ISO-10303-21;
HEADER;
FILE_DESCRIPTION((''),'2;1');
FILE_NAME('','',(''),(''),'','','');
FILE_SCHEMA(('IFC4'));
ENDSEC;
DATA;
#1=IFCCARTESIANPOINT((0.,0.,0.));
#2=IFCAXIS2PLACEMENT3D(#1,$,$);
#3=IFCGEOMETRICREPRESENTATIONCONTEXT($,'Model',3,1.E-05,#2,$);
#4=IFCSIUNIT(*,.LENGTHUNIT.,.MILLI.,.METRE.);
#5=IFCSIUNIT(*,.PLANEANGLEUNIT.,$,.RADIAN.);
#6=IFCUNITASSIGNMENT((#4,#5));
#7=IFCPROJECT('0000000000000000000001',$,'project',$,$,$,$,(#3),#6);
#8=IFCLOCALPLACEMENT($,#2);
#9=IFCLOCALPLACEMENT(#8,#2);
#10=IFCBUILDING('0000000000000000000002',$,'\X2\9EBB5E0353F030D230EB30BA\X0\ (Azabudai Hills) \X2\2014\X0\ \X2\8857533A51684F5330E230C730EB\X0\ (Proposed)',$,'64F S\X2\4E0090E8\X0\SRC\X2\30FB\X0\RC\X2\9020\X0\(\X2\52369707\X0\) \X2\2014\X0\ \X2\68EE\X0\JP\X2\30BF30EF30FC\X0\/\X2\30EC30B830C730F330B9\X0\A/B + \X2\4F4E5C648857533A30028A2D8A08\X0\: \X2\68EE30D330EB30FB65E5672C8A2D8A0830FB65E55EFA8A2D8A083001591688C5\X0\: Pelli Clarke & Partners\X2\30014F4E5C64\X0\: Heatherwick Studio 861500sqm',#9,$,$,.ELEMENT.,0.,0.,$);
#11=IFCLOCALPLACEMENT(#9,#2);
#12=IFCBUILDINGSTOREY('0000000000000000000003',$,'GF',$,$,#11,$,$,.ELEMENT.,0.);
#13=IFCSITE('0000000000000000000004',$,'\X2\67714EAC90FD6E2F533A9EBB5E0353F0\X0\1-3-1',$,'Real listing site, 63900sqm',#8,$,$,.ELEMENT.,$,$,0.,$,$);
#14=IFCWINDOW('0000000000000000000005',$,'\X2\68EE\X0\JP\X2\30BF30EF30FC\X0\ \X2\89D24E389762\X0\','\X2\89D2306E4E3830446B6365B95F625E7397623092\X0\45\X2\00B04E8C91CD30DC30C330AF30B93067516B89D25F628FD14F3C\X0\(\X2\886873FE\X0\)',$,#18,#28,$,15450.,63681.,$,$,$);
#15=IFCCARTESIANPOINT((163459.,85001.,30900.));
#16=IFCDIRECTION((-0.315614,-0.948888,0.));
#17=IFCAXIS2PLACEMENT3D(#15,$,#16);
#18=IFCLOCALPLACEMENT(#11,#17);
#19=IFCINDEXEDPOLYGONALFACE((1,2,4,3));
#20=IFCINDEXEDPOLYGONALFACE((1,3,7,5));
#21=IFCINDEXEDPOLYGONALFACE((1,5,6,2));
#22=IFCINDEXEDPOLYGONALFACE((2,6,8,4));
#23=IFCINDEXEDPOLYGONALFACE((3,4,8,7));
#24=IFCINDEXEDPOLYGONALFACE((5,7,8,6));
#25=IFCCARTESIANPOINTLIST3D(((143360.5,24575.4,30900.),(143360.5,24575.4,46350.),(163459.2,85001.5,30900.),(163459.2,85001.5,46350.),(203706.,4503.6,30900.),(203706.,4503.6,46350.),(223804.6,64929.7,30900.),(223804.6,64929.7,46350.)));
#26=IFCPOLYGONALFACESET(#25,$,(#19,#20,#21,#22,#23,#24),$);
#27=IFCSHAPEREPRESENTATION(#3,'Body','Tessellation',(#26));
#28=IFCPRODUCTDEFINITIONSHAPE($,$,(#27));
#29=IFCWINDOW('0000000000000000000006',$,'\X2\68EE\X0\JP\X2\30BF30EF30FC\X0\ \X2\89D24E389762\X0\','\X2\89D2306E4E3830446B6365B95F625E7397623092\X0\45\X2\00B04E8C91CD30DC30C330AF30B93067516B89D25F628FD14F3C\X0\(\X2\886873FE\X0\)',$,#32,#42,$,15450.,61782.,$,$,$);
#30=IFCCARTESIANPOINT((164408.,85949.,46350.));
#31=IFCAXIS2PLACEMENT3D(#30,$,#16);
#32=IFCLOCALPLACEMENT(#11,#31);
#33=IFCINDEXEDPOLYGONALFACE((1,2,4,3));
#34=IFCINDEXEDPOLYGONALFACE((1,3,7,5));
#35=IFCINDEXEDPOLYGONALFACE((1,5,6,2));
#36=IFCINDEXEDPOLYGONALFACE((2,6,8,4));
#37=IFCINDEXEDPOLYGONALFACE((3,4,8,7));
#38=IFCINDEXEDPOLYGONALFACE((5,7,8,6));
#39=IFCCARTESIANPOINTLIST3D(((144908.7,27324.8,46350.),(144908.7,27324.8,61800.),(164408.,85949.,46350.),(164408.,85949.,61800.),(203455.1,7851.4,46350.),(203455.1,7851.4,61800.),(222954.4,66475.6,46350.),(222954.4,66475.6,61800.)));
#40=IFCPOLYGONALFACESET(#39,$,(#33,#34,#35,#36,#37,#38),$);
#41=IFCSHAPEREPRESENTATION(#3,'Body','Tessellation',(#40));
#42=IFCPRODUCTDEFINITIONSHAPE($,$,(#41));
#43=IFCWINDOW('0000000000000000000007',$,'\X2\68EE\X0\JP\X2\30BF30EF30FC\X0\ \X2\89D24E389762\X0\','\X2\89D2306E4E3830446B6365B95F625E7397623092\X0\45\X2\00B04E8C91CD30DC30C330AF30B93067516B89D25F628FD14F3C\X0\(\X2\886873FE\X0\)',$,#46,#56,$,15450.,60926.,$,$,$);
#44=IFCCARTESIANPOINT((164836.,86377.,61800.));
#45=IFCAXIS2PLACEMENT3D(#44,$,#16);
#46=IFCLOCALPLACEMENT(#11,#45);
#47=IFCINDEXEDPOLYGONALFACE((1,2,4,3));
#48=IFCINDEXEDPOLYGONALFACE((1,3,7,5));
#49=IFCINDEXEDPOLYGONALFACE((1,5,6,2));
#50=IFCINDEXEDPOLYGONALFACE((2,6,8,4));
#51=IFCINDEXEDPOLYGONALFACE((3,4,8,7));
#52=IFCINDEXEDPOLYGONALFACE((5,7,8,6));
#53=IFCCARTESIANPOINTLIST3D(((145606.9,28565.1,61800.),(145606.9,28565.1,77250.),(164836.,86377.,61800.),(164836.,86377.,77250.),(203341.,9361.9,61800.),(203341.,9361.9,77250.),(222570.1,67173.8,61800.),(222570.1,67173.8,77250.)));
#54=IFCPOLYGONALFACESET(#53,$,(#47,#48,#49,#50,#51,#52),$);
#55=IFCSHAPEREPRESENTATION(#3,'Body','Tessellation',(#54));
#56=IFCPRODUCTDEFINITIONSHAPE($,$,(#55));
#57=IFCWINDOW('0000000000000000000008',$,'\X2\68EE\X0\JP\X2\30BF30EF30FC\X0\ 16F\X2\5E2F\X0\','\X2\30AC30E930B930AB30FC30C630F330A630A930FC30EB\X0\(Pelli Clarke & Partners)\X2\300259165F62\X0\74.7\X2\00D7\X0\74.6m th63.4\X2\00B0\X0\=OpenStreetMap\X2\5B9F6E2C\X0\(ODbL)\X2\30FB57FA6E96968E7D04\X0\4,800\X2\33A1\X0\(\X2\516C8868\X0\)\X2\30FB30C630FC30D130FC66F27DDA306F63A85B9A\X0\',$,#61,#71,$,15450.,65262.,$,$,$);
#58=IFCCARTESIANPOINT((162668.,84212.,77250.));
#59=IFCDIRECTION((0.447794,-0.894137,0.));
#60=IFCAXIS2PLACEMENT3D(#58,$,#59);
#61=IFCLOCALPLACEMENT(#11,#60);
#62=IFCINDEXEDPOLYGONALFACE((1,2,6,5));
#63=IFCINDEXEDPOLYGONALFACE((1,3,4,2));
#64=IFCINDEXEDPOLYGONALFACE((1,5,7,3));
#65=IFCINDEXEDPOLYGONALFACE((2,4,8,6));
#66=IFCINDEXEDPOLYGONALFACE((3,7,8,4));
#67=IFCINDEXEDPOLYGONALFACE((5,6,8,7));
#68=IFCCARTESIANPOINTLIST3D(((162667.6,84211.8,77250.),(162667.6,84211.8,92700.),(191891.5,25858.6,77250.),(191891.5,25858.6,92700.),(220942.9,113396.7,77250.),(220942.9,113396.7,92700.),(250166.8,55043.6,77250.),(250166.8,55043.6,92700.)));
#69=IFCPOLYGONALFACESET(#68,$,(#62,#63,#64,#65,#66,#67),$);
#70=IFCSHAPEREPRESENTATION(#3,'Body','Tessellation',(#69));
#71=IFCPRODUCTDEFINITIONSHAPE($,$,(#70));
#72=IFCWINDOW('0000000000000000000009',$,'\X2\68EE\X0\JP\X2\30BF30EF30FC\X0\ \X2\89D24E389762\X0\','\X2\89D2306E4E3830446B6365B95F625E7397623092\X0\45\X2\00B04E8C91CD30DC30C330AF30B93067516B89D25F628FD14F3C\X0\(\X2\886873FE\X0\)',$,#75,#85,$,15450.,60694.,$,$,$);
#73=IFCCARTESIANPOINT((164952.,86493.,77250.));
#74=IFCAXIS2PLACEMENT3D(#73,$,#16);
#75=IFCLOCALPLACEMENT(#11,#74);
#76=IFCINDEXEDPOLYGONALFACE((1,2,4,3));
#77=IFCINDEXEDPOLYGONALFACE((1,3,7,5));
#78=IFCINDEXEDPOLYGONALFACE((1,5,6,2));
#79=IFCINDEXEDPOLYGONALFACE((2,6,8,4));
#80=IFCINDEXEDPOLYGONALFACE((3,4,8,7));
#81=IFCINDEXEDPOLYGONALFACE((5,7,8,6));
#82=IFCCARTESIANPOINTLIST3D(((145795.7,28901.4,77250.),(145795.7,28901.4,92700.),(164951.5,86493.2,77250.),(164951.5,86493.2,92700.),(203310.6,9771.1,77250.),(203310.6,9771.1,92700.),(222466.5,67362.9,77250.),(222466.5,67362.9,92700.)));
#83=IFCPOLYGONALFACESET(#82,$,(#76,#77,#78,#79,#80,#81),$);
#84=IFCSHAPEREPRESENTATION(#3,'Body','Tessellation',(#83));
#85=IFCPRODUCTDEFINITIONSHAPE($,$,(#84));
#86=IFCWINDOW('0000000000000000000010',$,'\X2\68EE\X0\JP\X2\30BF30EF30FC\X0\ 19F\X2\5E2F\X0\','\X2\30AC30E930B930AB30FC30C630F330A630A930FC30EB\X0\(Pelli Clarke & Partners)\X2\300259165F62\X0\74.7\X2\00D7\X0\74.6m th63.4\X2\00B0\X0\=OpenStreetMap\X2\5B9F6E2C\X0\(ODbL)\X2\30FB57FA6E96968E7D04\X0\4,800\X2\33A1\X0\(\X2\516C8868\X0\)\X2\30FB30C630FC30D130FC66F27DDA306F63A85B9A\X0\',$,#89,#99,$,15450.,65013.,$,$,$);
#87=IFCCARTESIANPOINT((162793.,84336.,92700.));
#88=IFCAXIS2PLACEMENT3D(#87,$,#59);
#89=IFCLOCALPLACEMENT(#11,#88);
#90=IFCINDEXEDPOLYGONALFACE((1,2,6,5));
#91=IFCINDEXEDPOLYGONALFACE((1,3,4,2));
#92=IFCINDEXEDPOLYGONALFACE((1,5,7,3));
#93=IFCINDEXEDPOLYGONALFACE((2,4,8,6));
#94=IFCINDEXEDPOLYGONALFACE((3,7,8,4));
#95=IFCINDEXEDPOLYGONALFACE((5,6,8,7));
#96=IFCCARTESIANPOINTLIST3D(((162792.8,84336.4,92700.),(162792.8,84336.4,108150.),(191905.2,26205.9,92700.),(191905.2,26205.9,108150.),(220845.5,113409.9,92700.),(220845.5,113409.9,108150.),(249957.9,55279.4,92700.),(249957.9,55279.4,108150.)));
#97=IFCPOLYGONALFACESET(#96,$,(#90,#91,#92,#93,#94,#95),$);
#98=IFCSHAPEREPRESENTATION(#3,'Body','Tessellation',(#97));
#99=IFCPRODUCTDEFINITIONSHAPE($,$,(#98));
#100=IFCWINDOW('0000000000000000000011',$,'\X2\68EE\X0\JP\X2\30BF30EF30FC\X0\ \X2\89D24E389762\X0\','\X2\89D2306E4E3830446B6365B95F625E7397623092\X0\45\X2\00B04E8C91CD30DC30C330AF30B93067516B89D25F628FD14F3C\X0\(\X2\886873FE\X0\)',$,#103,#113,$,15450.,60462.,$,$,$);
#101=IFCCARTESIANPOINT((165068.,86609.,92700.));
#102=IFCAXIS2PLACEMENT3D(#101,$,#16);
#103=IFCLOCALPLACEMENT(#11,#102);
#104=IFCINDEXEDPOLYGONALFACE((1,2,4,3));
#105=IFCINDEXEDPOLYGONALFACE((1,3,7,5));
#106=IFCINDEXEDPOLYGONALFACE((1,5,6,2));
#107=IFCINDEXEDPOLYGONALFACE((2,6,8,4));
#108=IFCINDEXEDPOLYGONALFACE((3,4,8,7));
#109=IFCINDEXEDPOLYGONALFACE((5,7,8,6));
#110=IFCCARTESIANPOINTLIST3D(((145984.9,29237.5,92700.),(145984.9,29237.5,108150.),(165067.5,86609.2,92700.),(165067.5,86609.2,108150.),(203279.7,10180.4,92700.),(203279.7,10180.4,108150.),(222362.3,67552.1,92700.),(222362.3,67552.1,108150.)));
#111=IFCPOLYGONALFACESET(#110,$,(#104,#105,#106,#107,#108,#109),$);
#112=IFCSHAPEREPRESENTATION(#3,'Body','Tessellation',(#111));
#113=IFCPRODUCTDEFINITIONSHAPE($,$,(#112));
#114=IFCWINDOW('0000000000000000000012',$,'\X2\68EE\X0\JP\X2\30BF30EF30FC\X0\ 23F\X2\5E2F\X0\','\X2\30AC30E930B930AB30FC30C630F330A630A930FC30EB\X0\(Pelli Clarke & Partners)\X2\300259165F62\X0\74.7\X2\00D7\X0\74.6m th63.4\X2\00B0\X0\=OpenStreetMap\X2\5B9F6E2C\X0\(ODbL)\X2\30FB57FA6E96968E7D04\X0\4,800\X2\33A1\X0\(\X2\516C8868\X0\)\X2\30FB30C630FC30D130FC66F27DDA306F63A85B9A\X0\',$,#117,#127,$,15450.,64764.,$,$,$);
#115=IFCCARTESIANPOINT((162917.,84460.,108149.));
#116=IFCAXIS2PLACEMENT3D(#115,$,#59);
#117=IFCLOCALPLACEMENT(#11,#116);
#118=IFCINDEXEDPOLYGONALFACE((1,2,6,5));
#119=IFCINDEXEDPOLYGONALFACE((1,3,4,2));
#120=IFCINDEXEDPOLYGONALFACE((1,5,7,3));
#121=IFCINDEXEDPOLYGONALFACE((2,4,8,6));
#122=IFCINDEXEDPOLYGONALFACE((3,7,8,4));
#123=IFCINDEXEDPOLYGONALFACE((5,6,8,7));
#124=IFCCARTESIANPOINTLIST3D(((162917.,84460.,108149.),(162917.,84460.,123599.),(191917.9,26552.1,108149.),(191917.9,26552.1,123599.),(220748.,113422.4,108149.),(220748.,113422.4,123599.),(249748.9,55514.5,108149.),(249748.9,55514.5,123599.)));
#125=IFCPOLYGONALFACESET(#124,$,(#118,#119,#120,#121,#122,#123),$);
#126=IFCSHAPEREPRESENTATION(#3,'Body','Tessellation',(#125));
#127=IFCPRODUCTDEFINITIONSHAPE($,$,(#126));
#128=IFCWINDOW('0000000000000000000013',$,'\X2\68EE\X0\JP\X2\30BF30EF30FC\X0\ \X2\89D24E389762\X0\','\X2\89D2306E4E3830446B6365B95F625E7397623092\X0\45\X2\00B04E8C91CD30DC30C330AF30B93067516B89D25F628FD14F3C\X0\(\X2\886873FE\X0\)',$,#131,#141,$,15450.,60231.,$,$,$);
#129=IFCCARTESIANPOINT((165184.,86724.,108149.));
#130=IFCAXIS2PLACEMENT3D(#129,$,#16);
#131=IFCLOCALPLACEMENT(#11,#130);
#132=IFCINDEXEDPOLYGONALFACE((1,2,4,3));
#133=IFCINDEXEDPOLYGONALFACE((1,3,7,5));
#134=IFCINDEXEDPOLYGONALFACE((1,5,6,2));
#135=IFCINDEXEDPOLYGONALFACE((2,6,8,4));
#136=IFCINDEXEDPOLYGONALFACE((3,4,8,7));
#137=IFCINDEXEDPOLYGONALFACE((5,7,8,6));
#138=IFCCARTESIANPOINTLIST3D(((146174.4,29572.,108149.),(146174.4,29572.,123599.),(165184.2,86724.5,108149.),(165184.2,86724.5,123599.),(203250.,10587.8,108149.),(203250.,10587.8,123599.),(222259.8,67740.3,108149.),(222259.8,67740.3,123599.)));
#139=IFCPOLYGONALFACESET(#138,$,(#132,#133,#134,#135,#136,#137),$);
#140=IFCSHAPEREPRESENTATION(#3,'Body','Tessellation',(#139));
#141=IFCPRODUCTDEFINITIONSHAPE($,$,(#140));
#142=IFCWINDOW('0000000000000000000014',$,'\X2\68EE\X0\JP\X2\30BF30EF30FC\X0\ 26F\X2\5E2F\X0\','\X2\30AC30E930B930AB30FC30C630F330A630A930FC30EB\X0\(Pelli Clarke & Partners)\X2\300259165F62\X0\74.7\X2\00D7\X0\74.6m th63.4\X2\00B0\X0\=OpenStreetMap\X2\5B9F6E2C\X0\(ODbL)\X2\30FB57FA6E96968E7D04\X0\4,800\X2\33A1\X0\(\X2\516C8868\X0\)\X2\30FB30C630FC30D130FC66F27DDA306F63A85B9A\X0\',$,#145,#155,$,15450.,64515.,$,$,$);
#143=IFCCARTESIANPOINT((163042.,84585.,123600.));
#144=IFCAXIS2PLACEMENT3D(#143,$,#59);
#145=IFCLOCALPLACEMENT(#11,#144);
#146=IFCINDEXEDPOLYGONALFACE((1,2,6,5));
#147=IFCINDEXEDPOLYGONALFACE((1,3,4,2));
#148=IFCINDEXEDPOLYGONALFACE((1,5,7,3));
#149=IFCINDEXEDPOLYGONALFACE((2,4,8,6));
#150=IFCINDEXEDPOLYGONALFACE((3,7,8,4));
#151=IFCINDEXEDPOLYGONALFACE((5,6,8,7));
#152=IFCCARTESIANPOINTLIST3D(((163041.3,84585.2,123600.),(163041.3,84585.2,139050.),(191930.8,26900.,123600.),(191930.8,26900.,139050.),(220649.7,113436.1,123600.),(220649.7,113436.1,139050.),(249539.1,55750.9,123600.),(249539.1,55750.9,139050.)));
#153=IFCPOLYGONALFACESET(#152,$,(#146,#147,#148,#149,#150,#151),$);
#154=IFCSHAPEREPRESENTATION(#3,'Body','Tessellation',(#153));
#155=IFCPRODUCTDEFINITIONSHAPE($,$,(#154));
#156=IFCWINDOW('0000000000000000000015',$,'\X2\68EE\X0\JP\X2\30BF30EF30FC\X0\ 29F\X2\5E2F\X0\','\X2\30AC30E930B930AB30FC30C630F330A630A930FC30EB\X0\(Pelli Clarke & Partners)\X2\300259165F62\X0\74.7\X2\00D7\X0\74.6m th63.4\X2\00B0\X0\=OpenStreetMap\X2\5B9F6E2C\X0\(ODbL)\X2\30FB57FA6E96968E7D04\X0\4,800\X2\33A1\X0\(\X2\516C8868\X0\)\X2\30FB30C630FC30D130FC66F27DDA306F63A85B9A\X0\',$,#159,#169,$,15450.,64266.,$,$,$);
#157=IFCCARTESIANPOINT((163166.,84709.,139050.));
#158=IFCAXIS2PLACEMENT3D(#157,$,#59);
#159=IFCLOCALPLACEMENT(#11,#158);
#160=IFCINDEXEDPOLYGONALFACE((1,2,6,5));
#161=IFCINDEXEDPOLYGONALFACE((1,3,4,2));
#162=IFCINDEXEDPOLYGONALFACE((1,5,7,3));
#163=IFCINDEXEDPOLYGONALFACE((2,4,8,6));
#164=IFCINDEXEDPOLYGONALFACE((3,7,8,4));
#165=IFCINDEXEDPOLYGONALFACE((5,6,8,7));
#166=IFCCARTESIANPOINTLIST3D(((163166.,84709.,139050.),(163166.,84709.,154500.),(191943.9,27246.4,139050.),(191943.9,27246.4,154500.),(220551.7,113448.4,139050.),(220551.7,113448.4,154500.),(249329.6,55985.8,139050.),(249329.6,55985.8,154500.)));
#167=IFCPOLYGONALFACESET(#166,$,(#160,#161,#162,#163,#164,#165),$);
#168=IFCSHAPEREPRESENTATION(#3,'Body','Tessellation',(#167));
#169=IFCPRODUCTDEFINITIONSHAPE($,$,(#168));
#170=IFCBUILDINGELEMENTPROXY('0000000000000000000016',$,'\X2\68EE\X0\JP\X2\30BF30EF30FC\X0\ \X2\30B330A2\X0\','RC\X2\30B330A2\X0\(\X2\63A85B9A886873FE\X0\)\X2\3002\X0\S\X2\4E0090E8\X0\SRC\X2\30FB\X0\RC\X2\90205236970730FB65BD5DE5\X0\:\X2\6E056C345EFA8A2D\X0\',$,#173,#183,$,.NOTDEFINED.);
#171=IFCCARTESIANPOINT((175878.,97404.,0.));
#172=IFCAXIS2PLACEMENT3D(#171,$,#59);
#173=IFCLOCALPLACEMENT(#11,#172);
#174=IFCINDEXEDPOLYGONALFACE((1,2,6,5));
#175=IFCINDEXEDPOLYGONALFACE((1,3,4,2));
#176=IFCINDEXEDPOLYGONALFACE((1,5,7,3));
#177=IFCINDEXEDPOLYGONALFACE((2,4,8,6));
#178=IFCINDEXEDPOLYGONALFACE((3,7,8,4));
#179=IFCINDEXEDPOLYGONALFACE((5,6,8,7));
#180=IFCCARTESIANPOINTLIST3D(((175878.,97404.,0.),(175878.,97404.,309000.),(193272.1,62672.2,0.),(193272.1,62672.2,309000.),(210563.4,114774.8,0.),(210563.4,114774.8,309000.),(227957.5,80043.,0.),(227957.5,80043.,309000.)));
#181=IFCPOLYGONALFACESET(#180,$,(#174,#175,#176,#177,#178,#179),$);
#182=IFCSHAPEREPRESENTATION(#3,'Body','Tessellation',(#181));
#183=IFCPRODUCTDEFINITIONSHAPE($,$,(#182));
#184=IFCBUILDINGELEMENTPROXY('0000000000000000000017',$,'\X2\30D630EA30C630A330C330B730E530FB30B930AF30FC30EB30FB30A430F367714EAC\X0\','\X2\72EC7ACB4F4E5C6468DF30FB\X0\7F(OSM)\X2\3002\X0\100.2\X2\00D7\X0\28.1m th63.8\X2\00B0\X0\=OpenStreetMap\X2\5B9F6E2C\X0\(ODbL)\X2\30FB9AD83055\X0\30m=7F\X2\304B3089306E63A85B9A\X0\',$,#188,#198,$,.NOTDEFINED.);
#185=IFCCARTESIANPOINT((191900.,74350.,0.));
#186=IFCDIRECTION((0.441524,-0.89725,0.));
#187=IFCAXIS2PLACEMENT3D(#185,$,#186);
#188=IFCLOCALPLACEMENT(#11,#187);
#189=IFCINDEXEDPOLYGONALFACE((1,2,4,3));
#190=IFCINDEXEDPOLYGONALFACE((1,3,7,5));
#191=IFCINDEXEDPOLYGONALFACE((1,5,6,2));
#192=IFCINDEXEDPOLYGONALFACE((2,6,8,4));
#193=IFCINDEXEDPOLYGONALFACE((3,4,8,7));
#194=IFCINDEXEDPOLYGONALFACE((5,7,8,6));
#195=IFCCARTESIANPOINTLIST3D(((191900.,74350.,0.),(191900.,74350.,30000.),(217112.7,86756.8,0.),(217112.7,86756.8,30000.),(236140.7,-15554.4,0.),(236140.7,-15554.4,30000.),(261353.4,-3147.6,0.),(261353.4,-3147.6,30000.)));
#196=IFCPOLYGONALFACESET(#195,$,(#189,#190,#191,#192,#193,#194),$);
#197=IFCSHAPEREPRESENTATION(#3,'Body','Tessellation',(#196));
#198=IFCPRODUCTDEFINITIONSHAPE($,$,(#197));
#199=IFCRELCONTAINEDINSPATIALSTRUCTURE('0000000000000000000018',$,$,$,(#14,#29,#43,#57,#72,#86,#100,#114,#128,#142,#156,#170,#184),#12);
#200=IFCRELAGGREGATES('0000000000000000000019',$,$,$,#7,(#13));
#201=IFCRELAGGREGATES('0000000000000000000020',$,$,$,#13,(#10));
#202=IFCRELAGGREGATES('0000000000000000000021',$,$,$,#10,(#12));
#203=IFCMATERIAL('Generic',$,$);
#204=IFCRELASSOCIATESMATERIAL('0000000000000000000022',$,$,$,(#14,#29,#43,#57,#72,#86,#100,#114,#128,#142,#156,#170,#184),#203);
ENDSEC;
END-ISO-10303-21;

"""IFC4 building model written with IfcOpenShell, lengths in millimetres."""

from ifc_helpers import new_model, si_unit, frame, frame_2d, origin, place, context, project, spatial, rectangle, extrude, material, element, save


model = new_model("IFC4")

# Units and contexts
model_context = context("Model", 3, precision=1e-05, world=origin())
ifc_project = project(units=[si_unit("LENGTHUNIT", "METRE", prefix="MILLI"), si_unit("PLANEANGLEUNIT", "RADIAN")], contexts=[model_context])

# Site, building, storey
site_placement = place(None, origin())
site = spatial("IfcSite", under=ifc_project, at=site_placement, Name="東京都港区麻布台1-3-1", ObjectType="Real listing site, 63900sqm", CompositionType="ELEMENT", RefElevation=0.0)
building_placement = place(site_placement, origin())
building = spatial("IfcBuilding", under=site, at=building_placement, Name="麻布台ヒルズ (Azabudai Hills) — 街区全体モデル (Proposed)", ObjectType="64F S一部SRC・RC造(制震) — 森JPタワー/レジデンスA/B + 低層街区。設計: 森ビル・日本設計・日建設計、外装: Pelli Clarke & Partners、低層: Heatherwick Studio 861500sqm", CompositionType="ELEMENT", ElevationOfRefHeight=0.0, ElevationOfTerrain=0.0)
storey_placement = place(building_placement, origin())
storey = spatial("IfcBuildingStorey", under=building, at=storey_placement, Name="GF", CompositionType="ELEMENT", Elevation=0.0)

# Windows
ifc_material = material(Name="Generic")
window_1_placement = place(storey_placement, frame((163459.0, 85001.0, 30900.0), x_axis=(-0.315614, -0.948888, 0.0)))
element("IfcWindow", 1, at=window_1_placement, inside=storey, material=ifc_material, Name="森JPタワー 角丸面", Description="角の丸い正方形平面を45°二重ボックスで八角形近似(表現)", OverallHeight=15450.0, OverallWidth=63681.0, context=model_context, shape_type="SweptSolid", body=[
    extrude(rectangle(XDim=63681.0, YDim=63596.0, at=frame_2d((31840.0, 31798.0))), frame((163459.0, 85001.0, 30900.0), x_axis=(-0.315614, -0.948888, 0.0)), (0.0, 0.0, 1.0), 15450.0),
])
window_2_placement = place(storey_placement, frame((164408.0, 85949.0, 46350.0), x_axis=(-0.315614, -0.948888, 0.0)))
element("IfcWindow", 2, at=window_2_placement, inside=storey, material=ifc_material, Name="森JPタワー 角丸面", Description="角の丸い正方形平面を45°二重ボックスで八角形近似(表現)", OverallHeight=15450.0, OverallWidth=61782.0, context=model_context, shape_type="SweptSolid", body=[
    extrude(rectangle(XDim=61782.0, YDim=61700.0, at=frame_2d((30891.0, 30850.0))), frame((164408.0, 85949.0, 46350.0), x_axis=(-0.315614, -0.948888, 0.0)), (0.0, 0.0, 1.0), 15450.0),
])
window_3_placement = place(storey_placement, frame((164836.0, 86377.0, 61800.0), x_axis=(-0.315614, -0.948888, 0.0)))
element("IfcWindow", 3, at=window_3_placement, inside=storey, material=ifc_material, Name="森JPタワー 角丸面", Description="角の丸い正方形平面を45°二重ボックスで八角形近似(表現)", OverallHeight=15450.0, OverallWidth=60926.0, context=model_context, shape_type="SweptSolid", body=[
    extrude(rectangle(XDim=60926.0, YDim=60844.0, at=frame_2d((30463.0, 30422.0))), frame((164836.0, 86377.0, 61800.0), x_axis=(-0.315614, -0.948888, 0.0)), (0.0, 0.0, 1.0), 15450.0),
])
window_4_placement = place(storey_placement, frame((162668.0, 84212.0, 77250.0), x_axis=(0.447794, -0.894137, 0.0)))
element("IfcWindow", 4, at=window_4_placement, inside=storey, material=ifc_material, Name="森JPタワー 16F帯", Description="ガラスカーテンウォール(Pelli Clarke & Partners)。外形74.7×74.6m th63.4°=OpenStreetMap実測(ODbL)・基準階約4,800㎡(公表)・テーパー曲線は推定", OverallHeight=15450.0, OverallWidth=65262.0, context=model_context, shape_type="SweptSolid", body=[
    extrude(rectangle(XDim=65262.0, YDim=65175.0, at=frame_2d((32631.0, 32587.0))), frame((162668.0, 84212.0, 77250.0), x_axis=(0.447794, -0.894137, 0.0)), (0.0, 0.0, 1.0), 15450.0),
])
window_5_placement = place(storey_placement, frame((164952.0, 86493.0, 77250.0), x_axis=(-0.315614, -0.948888, 0.0)))
element("IfcWindow", 5, at=window_5_placement, inside=storey, material=ifc_material, Name="森JPタワー 角丸面", Description="角の丸い正方形平面を45°二重ボックスで八角形近似(表現)", OverallHeight=15450.0, OverallWidth=60694.0, context=model_context, shape_type="SweptSolid", body=[
    extrude(rectangle(XDim=60694.0, YDim=60613.0, at=frame_2d((30347.0, 30306.0))), frame((164952.0, 86493.0, 77250.0), x_axis=(-0.315614, -0.948888, 0.0)), (0.0, 0.0, 1.0), 15450.0),
])
window_6_placement = place(storey_placement, frame((162793.0, 84336.0, 92700.0), x_axis=(0.447794, -0.894137, 0.0)))
element("IfcWindow", 6, at=window_6_placement, inside=storey, material=ifc_material, Name="森JPタワー 19F帯", Description="ガラスカーテンウォール(Pelli Clarke & Partners)。外形74.7×74.6m th63.4°=OpenStreetMap実測(ODbL)・基準階約4,800㎡(公表)・テーパー曲線は推定", OverallHeight=15450.0, OverallWidth=65013.0, context=model_context, shape_type="SweptSolid", body=[
    extrude(rectangle(XDim=65013.0, YDim=64926.0, at=frame_2d((32506.0, 32463.0))), frame((162793.0, 84336.0, 92700.0), x_axis=(0.447794, -0.894137, 0.0)), (0.0, 0.0, 1.0), 15450.0),
])
window_7_placement = place(storey_placement, frame((165068.0, 86609.0, 92700.0), x_axis=(-0.315614, -0.948888, 0.0)))
element("IfcWindow", 7, at=window_7_placement, inside=storey, material=ifc_material, Name="森JPタワー 角丸面", Description="角の丸い正方形平面を45°二重ボックスで八角形近似(表現)", OverallHeight=15450.0, OverallWidth=60462.0, context=model_context, shape_type="SweptSolid", body=[
    extrude(rectangle(XDim=60462.0, YDim=60381.0, at=frame_2d((30231.0, 30190.0))), frame((165068.0, 86609.0, 92700.0), x_axis=(-0.315614, -0.948888, 0.0)), (0.0, 0.0, 1.0), 15450.0),
])
window_8_placement = place(storey_placement, frame((162917.0, 84460.0, 108149.0), x_axis=(0.447794, -0.894137, 0.0)))
element("IfcWindow", 8, at=window_8_placement, inside=storey, material=ifc_material, Name="森JPタワー 23F帯", Description="ガラスカーテンウォール(Pelli Clarke & Partners)。外形74.7×74.6m th63.4°=OpenStreetMap実測(ODbL)・基準階約4,800㎡(公表)・テーパー曲線は推定", OverallHeight=15450.0, OverallWidth=64764.0, context=model_context, shape_type="SweptSolid", body=[
    extrude(rectangle(XDim=64764.0, YDim=64678.0, at=frame_2d((32382.0, 32339.0))), frame((162917.0, 84460.0, 108149.0), x_axis=(0.447794, -0.894137, 0.0)), (0.0, 0.0, 1.0), 15450.0),
])
window_9_placement = place(storey_placement, frame((165184.0, 86724.0, 108149.0), x_axis=(-0.315614, -0.948888, 0.0)))
element("IfcWindow", 9, at=window_9_placement, inside=storey, material=ifc_material, Name="森JPタワー 角丸面", Description="角の丸い正方形平面を45°二重ボックスで八角形近似(表現)", OverallHeight=15450.0, OverallWidth=60231.0, context=model_context, shape_type="SweptSolid", body=[
    extrude(rectangle(XDim=60231.0, YDim=60150.0, at=frame_2d((30115.0, 30075.0))), frame((165184.0, 86724.0, 108149.0), x_axis=(-0.315614, -0.948888, 0.0)), (0.0, 0.0, 1.0), 15450.0),
])
window_10_placement = place(storey_placement, frame((163042.0, 84585.0, 123600.0), x_axis=(0.447794, -0.894137, 0.0)))
element("IfcWindow", 10, at=window_10_placement, inside=storey, material=ifc_material, Name="森JPタワー 26F帯", Description="ガラスカーテンウォール(Pelli Clarke & Partners)。外形74.7×74.6m th63.4°=OpenStreetMap実測(ODbL)・基準階約4,800㎡(公表)・テーパー曲線は推定", OverallHeight=15450.0, OverallWidth=64515.0, context=model_context, shape_type="SweptSolid", body=[
    extrude(rectangle(XDim=64515.0, YDim=64429.0, at=frame_2d((32257.0, 32214.0))), frame((163042.0, 84585.0, 123600.0), x_axis=(0.447794, -0.894137, 0.0)), (0.0, 0.0, 1.0), 15450.0),
])
window_11_placement = place(storey_placement, frame((163166.0, 84709.0, 139050.0), x_axis=(0.447794, -0.894137, 0.0)))
element("IfcWindow", 11, at=window_11_placement, inside=storey, material=ifc_material, Name="森JPタワー 29F帯", Description="ガラスカーテンウォール(Pelli Clarke & Partners)。外形74.7×74.6m th63.4°=OpenStreetMap実測(ODbL)・基準階約4,800㎡(公表)・テーパー曲線は推定", OverallHeight=15450.0, OverallWidth=64266.0, context=model_context, shape_type="SweptSolid", body=[
    extrude(rectangle(XDim=64266.0, YDim=64180.0, at=frame_2d((32133.0, 32090.0))), frame((163166.0, 84709.0, 139050.0), x_axis=(0.447794, -0.894137, 0.0)), (0.0, 0.0, 1.0), 15450.0),
])

# Building element proxies
proxy_1_placement = place(storey_placement, frame((175878.0, 97404.0, 0.0), x_axis=(0.447794, -0.894137, 0.0)))
element("IfcBuildingElementProxy", 12, at=proxy_1_placement, inside=storey, material=ifc_material, Name="森JPタワー コア", Description="RCコア(推定表現)。S一部SRC・RC造制震・施工:清水建設", PredefinedType="NOTDEFINED", context=model_context, shape_type="SweptSolid", body=[
    extrude(rectangle(XDim=38844.0, YDim=38792.0, at=frame_2d((19422.0, 19396.0))), frame((175878.0, 97404.0, 0.0), x_axis=(0.447794, -0.894137, 0.0)), (0.0, 0.0, 1.0), 309000.0),
])
proxy_2_placement = place(storey_placement, frame((191900.0, 74350.0, 0.0), x_axis=(0.441524, -0.89725, 0.0)))
element("IfcBuildingElementProxy", 13, at=proxy_2_placement, inside=storey, material=ifc_material, Name="ブリティッシュ・スクール・イン東京", Description="独立低層棟・7F(OSM)。100.2×28.1m th63.8°=OpenStreetMap実測(ODbL)・高さ30m=7Fからの推定", PredefinedType="NOTDEFINED", context=model_context, shape_type="SweptSolid", body=[
    extrude(rectangle(XDim=100200.0, YDim=28100.0, at=frame_2d((50100.0, 14050.0))), frame((191900.0, 74350.0, 0.0), x_axis=(0.441524, -0.89725, 0.0)), (0.0, 0.0, 1.0), 30000.0),
])

save(model, "model.ifc")
